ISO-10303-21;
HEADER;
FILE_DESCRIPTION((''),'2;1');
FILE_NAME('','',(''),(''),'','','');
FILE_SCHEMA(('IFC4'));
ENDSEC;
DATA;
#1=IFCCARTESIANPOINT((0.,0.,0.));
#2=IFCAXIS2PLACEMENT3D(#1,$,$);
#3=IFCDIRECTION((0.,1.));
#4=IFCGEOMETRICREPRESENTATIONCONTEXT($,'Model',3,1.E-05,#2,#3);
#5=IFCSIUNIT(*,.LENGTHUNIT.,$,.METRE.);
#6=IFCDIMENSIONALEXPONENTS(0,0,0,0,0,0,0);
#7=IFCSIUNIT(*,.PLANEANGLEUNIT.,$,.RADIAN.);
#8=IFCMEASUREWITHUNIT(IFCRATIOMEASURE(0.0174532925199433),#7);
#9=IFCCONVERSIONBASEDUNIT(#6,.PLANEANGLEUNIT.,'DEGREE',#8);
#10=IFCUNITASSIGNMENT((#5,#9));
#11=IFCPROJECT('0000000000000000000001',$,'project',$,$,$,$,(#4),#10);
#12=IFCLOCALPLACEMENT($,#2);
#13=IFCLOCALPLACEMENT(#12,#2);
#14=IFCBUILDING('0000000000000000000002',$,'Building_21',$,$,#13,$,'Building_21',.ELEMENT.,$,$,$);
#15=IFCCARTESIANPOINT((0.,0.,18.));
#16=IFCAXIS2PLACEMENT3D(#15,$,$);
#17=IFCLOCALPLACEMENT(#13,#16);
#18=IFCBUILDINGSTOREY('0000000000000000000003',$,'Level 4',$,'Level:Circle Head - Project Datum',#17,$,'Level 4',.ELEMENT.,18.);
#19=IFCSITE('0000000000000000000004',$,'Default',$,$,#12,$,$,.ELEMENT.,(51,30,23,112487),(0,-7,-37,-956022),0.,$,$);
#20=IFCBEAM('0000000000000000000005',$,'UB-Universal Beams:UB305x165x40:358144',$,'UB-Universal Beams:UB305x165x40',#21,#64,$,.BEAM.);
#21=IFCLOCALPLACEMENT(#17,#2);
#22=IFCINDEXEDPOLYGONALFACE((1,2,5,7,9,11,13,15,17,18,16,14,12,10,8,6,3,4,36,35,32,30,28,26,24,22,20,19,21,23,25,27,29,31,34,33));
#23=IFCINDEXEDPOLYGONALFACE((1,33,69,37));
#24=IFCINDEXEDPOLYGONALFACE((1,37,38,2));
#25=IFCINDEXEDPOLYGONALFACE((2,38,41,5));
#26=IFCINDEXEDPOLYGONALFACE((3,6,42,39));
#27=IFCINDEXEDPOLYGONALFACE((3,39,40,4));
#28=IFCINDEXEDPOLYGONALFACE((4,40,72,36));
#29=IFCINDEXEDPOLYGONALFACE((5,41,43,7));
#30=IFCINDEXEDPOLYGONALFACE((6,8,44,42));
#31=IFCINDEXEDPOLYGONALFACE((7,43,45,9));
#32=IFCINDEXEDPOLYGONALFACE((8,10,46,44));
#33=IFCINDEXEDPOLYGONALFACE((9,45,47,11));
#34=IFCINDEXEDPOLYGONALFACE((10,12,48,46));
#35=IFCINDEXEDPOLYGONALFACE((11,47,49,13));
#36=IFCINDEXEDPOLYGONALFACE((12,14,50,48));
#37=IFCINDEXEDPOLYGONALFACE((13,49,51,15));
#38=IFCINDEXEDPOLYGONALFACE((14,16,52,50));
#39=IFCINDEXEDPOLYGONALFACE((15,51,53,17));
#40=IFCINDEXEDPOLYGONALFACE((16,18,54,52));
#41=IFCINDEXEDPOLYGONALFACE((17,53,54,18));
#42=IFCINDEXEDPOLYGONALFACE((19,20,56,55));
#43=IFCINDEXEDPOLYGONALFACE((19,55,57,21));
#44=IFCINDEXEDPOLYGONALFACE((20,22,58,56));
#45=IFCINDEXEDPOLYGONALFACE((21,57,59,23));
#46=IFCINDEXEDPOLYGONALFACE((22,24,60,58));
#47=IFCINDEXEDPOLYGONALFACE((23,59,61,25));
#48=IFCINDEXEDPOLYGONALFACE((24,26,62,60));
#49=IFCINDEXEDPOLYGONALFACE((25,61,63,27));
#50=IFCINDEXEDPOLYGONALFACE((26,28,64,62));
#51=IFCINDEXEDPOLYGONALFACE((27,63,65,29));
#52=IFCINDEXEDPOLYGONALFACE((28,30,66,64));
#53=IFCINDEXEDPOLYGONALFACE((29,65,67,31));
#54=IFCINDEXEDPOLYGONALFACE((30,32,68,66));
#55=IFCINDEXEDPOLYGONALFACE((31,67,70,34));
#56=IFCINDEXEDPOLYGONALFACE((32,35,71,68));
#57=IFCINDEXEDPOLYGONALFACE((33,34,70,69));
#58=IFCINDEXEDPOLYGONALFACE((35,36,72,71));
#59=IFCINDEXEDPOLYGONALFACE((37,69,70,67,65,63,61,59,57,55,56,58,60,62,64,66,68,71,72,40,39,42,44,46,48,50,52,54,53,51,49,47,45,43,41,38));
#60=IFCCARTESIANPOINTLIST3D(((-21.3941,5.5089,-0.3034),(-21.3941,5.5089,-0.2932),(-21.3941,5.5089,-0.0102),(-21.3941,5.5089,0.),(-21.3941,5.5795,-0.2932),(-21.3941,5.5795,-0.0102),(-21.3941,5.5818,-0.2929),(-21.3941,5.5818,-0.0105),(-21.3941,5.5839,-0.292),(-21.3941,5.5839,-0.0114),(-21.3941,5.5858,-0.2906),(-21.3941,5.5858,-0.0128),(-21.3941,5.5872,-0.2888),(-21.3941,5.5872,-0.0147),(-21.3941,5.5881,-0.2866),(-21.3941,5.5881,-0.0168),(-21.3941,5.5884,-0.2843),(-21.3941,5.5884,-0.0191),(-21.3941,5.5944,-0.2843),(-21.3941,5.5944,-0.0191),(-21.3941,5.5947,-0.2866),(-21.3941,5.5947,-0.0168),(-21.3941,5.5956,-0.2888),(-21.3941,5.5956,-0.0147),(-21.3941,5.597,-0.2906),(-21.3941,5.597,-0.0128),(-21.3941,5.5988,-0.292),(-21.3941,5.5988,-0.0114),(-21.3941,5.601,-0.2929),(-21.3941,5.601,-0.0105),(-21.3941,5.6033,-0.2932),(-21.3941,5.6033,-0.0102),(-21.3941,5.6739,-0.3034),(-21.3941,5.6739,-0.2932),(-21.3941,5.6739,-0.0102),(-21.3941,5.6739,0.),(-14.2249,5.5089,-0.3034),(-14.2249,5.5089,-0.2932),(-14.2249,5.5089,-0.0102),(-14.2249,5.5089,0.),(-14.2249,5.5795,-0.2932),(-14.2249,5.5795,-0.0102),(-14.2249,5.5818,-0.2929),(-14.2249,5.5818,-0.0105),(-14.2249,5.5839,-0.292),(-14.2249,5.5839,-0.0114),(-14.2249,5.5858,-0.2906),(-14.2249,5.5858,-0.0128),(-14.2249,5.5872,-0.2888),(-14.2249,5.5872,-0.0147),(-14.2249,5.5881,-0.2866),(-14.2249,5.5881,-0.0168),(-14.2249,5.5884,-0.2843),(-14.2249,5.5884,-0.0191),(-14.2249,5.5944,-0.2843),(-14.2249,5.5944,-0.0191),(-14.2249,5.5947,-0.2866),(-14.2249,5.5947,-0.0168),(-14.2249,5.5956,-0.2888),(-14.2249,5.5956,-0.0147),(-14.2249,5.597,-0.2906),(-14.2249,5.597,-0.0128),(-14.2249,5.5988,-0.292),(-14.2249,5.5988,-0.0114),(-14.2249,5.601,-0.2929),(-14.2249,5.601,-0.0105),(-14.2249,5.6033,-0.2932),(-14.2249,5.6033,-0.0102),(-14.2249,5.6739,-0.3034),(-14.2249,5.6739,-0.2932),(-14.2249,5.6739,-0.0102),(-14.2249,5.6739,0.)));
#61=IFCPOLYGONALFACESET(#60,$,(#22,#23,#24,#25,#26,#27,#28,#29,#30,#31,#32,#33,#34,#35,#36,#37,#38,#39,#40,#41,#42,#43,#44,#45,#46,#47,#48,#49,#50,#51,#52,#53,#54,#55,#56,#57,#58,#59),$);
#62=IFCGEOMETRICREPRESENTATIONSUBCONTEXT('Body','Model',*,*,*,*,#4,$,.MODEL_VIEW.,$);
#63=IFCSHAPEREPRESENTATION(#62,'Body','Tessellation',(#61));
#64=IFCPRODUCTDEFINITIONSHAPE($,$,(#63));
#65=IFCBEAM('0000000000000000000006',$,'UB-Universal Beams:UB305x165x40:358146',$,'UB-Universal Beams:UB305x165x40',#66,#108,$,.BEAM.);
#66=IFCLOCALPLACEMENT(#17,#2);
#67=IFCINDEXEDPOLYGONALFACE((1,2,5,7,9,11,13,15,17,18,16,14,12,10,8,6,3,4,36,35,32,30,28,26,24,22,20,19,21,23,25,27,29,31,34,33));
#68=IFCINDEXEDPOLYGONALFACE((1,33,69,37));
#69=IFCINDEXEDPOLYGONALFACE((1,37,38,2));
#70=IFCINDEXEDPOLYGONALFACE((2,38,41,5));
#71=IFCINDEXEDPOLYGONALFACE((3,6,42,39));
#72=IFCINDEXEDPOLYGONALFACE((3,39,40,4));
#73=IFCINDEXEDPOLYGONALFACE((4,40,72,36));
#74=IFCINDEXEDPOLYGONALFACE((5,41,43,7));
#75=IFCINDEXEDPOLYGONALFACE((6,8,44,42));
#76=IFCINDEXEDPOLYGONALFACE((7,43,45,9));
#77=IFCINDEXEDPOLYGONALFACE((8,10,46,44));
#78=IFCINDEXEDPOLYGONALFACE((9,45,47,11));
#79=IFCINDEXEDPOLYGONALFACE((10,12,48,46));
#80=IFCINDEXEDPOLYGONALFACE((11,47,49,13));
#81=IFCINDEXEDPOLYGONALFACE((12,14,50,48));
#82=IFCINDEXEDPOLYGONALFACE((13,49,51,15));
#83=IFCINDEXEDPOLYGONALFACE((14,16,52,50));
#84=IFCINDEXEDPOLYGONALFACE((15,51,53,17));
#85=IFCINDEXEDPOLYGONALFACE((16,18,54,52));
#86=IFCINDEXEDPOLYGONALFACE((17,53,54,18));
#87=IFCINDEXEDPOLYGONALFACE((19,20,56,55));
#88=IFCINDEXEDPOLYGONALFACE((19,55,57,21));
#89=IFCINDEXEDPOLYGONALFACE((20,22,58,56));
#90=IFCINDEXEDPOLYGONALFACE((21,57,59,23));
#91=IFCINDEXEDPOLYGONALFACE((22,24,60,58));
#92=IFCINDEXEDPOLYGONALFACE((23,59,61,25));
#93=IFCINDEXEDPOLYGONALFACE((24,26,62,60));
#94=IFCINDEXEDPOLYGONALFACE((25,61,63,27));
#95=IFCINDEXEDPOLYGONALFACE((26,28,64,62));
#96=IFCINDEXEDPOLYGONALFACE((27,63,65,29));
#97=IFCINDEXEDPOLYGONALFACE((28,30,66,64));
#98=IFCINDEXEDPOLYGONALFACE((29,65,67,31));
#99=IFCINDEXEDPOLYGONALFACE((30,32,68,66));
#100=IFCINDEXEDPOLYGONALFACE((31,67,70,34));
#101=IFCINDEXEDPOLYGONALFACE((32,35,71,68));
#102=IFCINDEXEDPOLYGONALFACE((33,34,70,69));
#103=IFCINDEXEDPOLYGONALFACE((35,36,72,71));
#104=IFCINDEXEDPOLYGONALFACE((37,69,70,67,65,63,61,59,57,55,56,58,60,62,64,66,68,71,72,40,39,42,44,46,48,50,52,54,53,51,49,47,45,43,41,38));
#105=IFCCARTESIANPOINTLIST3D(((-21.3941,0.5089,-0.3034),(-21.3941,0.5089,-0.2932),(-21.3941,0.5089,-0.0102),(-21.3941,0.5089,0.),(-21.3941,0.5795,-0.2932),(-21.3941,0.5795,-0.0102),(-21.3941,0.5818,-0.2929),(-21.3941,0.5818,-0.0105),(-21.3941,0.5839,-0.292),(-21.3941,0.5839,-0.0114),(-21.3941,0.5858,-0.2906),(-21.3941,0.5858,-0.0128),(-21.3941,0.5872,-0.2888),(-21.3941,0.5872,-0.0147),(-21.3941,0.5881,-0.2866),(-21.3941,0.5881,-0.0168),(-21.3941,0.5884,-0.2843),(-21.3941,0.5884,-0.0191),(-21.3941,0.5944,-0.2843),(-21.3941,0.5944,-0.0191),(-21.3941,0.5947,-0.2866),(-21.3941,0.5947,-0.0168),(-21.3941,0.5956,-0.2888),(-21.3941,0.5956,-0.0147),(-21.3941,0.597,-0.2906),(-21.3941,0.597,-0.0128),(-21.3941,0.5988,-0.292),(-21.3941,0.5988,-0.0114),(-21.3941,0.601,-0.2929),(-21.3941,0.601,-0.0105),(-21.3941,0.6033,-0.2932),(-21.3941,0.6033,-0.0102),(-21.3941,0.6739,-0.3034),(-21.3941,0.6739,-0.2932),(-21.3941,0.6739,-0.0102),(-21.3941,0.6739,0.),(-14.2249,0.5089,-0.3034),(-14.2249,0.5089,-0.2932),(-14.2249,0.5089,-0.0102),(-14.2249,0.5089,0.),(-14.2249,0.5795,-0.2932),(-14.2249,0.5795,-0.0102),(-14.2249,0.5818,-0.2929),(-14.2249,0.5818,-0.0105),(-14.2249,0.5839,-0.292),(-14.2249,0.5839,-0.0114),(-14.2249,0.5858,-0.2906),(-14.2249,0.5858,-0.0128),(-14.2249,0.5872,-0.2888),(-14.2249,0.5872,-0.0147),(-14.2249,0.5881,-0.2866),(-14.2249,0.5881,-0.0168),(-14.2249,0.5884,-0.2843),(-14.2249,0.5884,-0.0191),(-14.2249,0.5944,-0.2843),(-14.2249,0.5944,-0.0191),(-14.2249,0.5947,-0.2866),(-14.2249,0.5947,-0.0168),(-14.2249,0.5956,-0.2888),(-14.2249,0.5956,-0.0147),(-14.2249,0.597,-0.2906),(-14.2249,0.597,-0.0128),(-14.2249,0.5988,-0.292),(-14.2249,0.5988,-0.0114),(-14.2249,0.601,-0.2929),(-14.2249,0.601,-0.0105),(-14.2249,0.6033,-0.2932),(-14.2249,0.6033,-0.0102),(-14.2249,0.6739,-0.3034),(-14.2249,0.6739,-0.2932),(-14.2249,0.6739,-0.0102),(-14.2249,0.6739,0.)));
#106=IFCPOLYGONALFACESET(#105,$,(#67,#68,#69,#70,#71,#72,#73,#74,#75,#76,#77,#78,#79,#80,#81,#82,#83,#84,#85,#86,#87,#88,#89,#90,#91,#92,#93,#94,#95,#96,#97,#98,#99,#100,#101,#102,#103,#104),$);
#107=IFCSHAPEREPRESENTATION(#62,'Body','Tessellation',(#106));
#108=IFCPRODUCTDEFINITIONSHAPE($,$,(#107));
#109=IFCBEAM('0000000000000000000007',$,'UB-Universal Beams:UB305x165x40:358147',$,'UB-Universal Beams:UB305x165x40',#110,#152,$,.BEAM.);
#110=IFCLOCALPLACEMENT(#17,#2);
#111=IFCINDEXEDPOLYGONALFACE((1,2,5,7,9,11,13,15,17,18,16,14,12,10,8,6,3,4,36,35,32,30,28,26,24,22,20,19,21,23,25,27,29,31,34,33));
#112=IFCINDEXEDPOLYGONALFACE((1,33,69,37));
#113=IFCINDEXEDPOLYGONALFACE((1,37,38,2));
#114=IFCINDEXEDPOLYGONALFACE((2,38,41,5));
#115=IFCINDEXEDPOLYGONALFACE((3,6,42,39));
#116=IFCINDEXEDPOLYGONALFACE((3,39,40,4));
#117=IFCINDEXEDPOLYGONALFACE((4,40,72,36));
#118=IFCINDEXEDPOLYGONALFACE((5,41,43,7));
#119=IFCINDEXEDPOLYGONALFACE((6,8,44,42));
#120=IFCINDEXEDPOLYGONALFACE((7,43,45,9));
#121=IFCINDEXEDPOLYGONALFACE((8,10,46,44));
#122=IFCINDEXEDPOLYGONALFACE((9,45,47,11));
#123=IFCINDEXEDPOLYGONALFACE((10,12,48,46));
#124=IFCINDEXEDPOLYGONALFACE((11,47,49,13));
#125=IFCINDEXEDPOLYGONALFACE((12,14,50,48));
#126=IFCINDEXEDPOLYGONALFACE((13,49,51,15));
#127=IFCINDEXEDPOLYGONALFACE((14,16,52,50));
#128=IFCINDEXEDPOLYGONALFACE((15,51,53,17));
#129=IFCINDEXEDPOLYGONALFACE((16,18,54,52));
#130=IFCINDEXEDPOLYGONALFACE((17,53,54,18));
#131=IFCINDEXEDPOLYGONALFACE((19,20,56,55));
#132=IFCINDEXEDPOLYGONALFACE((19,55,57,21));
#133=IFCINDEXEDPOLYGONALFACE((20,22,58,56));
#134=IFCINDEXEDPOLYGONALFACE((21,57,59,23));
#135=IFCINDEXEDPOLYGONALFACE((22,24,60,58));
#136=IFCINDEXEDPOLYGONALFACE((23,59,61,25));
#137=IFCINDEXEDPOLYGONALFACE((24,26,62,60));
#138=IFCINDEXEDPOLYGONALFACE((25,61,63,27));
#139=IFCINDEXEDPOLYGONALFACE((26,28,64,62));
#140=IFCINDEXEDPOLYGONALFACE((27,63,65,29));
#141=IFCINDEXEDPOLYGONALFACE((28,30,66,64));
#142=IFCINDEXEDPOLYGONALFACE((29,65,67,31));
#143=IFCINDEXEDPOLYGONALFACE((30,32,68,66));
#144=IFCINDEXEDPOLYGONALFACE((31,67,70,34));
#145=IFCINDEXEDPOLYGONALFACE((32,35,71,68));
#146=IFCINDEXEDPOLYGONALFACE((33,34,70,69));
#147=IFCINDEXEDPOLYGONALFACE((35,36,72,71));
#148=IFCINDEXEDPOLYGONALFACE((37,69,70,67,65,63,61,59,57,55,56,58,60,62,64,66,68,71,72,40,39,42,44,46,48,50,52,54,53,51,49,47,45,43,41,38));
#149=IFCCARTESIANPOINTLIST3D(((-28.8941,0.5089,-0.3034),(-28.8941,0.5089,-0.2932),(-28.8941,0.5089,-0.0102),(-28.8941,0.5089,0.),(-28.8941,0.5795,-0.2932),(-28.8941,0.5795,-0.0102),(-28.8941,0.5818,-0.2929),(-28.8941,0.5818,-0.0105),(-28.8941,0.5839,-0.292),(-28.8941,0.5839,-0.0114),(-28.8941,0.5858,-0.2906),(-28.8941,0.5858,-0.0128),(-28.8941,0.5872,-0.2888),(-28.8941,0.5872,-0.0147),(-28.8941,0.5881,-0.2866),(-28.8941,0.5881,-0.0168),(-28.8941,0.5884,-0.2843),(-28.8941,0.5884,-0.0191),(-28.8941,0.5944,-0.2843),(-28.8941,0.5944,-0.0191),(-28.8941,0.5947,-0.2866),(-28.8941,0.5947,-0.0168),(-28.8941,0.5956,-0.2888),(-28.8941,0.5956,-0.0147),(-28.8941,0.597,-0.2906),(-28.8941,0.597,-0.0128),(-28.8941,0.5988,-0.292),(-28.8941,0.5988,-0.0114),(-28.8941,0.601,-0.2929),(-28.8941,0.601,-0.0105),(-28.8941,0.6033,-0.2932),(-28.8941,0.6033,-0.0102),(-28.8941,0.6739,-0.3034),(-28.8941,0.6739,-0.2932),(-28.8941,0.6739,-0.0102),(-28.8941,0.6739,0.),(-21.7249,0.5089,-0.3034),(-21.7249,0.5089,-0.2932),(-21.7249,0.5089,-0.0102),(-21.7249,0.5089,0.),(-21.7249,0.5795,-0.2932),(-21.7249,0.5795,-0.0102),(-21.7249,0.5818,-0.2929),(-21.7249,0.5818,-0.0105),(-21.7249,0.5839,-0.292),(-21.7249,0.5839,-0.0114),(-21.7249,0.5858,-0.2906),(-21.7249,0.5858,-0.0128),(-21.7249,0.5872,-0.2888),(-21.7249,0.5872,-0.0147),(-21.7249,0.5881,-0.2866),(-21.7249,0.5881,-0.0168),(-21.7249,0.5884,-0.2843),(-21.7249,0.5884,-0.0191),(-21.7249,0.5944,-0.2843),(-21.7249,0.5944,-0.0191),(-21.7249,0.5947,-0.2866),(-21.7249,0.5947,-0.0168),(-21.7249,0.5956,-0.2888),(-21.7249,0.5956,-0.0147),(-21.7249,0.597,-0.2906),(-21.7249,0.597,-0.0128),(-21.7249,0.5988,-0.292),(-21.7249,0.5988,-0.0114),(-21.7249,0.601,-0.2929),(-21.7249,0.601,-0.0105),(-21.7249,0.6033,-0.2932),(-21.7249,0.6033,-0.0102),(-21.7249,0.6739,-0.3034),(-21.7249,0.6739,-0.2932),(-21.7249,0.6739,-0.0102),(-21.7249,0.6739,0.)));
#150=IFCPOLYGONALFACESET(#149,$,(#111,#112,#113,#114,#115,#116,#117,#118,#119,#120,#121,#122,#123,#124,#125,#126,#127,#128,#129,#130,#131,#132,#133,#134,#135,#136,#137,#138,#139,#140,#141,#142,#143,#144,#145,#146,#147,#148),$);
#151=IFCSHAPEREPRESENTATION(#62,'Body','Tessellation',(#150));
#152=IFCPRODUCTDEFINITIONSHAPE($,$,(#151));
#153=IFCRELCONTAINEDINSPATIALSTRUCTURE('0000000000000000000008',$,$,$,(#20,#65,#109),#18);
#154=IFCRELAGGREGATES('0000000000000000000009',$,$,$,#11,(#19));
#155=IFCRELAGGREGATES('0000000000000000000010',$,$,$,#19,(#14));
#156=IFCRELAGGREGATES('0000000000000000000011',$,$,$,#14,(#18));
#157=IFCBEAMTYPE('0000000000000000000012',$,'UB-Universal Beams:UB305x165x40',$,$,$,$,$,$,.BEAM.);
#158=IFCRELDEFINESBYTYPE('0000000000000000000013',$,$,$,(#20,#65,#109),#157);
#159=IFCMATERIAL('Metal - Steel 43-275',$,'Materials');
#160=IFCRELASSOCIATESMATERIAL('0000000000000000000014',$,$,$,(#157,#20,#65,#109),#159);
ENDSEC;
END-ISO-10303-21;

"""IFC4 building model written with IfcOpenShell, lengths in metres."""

from ifc_helpers import new_model, entity, si_unit, converted_unit, direction, frame, frame_2d, origin, place, context, subcontext, project, spatial, polyline, circle_curve, parameter, trimmed, segment, composite_curve, i_section, outline, extrude, source, transform, mapped, material, material_profile, profile_set, profile_usage, type_object, type_shapes, element, save


model = new_model("IFC4")

# Units and contexts
model_context = context("Model", 3, precision=1e-05, world=origin(), true_north=direction((0.0, 1.0)))
body_context = subcontext(model_context, "Body", "Model", "MODEL_VIEW")
ifc_project = project(units=[si_unit("LENGTHUNIT", "METRE"), converted_unit("PLANEANGLEUNIT", "DEGREE", entity("IfcRatioMeasure", 0.0174532925199433), si_unit("PLANEANGLEUNIT", "RADIAN"), dimensions=[0, 0, 0, 0, 0, 0, 0])], contexts=[model_context])

# Site, building, storey
site_placement = place(None, origin())
site = spatial("IfcSite", under=ifc_project, at=site_placement, Name="Default", CompositionType="ELEMENT", RefLatitude=(51, 30, 23, 112487), RefLongitude=(0, -7, -37, -956022), RefElevation=0.0)
building_placement = place(site_placement, origin())
building = spatial("IfcBuilding", under=site, at=building_placement, Name="Building_21", LongName="Building_21", CompositionType="ELEMENT")
storey_placement = place(building_placement, frame((0.0, 0.0, 18.0)))
storey = spatial("IfcBuildingStorey", under=building, at=storey_placement, Name="Level 4", ObjectType="Level:Circle Head - Project Datum", LongName="Level 4", CompositionType="ELEMENT", Elevation=18.0)

# Beams
ifc_material_1 = material(Name="Metal - Steel 43-275", Category="Materials")
ifc_material_profile_1 = material_profile(ifc_material_1, outline(composite_curve([segment(polyline([(0.0119, -0.1415, 0.0), (0.0825, -0.1415, 0.0)]), True, "CONTINUOUS"), segment(polyline([(0.0825, -0.1415, 0.0), (0.0825, -0.1517, 0.0)]), True, "CONTINUOUS"), segment(polyline([(0.0825, -0.1517, 0.0), (-0.0825, -0.1517, 0.0)]), True, "CONTINUOUS"), segment(polyline([(-0.0825, -0.1517, 0.0), (-0.0825, -0.1415, 0.0)]), True, "CONTINUOUS"), segment(polyline([(-0.0825, -0.1415, 0.0), (-0.0119, -0.1415, 0.0)]), True, "CONTINUOUS"), segment(trimmed(circle_curve(frame((-0.0119, -0.1326, 0.0), z_axis=(0.0, 0.0, 1.0), x_axis=(-1.0, 0.0, 0.0)), 0.0089), [parameter(90.0)], [parameter(180.0)], True, "PARAMETER"), True, "CONTINUOUS"), segment(polyline([(-0.003, -0.1326, 0.0), (-0.003, 0.1326, 0.0)]), True, "CONTINUOUS"), segment(trimmed(circle_curve(frame((-0.0119, 0.1326, 0.0), z_axis=(0.0, 0.0, 1.0), x_axis=(-1.0, 0.0, 0.0)), 0.0089), [parameter(180.0)], [parameter(270.0)], True, "PARAMETER"), True, "CONTINUOUS"), segment(polyline([(-0.0119, 0.1415, 0.0), (-0.0825, 0.1415, 0.0)]), True, "CONTINUOUS"), segment(polyline([(-0.0825, 0.1415, 0.0), (-0.0825, 0.1517, 0.0)]), True, "CONTINUOUS"), segment(polyline([(-0.0825, 0.1517, 0.0), (0.0825, 0.1517, 0.0)]), True, "CONTINUOUS"), segment(polyline([(0.0825, 0.1517, 0.0), (0.0825, 0.1415, 0.0)]), True, "CONTINUOUS"), segment(polyline([(0.0825, 0.1415, 0.0), (0.0119, 0.1415, 0.0)]), True, "CONTINUOUS"), segment(trimmed(circle_curve(frame((0.0119, 0.1326, 0.0), z_axis=(0.0, 0.0, 1.0), x_axis=(-1.0, 0.0, 0.0)), 0.0089), [parameter(270.0)], [parameter(0.0)], True, "PARAMETER"), True, "CONTINUOUS"), segment(polyline([(0.003, 0.1326, 0.0), (0.003, -0.1326, 0.0)]), True, "CONTINUOUS"), segment(trimmed(circle_curve(frame((0.0119, -0.1326, 0.0), z_axis=(0.0, 0.0, 1.0), x_axis=(-1.0, 0.0, 0.0)), 0.0089), [parameter(0.0)], [parameter(90.0)], True, "PARAMETER"), True, "CONTINUOUS")], self_intersect=False), kind="CURVE"), Name="UB305x165x40")
ifc_material_profile_2 = material_profile(ifc_material_1, outline(composite_curve([segment(polyline([(-1.3346, 0.0825, -0.1415), (-1.3346, 0.0825, -0.1517)]), True, "CONTINUOUS"), segment(polyline([(-1.3346, 0.0825, -0.1517), (-1.3346, -0.0825, -0.1517)]), True, "CONTINUOUS"), segment(polyline([(-1.3346, -0.0825, -0.1517), (-1.3346, -0.0825, -0.1415)]), True, "CONTINUOUS"), segment(polyline([(-1.3346, -0.0825, -0.1415), (-1.3346, -0.003, -0.1415)]), True, "CONTINUOUS"), segment(polyline([(-1.3346, -0.003, -0.1415), (-1.3346, -0.003, 0.1415)]), True, "CONTINUOUS"), segment(polyline([(-1.3346, -0.003, 0.1415), (-1.3346, -0.0825, 0.1415)]), True, "CONTINUOUS"), segment(polyline([(-1.3346, -0.0825, 0.1415), (-1.3346, -0.0825, 0.1517)]), True, "CONTINUOUS"), segment(polyline([(-1.3346, -0.0825, 0.1517), (-1.3346, 0.0825, 0.1517)]), True, "CONTINUOUS"), segment(polyline([(-1.3346, 0.0825, 0.1517), (-1.3346, 0.0825, 0.1415)]), True, "CONTINUOUS"), segment(polyline([(-1.3346, 0.0825, 0.1415), (-1.3346, 0.003, 0.1415)]), True, "CONTINUOUS"), segment(polyline([(-1.3346, 0.003, 0.1415), (-1.3346, 0.003, -0.1415)]), True, "CONTINUOUS"), segment(polyline([(-1.3346, 0.003, -0.1415), (-1.3346, 0.0825, -0.1415)]), True, "CONTINUOUS")], self_intersect=False), kind="CURVE"), Name="UB305x165x40")
ifc_profile_set = profile_set([ifc_material_profile_1, ifc_material_profile_2], Name="UB305x165x40")
beam_type_1 = type_object("IfcBeamType", Name="UB-Universal Beams:UB305x165x40", PredefinedType="BEAM", material=ifc_profile_set)
shared_shape_1 = source(origin(), body_context, "Body", "SweptSolid", [
    extrude(i_section(OverallWidth=0.165, OverallDepth=0.3034, WebThickness=0.006, FlangeThickness=0.0102, FilletRadius=0.0089, at=frame_2d((0.0, 0.0), x_axis=(0.0, 1.0))), frame((-3.5846, 0.0, 0.0), z_axis=(1.0, 0.0, 0.0), x_axis=(0.0, 0.0, -1.0)), (0.0, 0.0, 1.0), 7.1692),
])
type_shapes(beam_type_1, [shared_shape_1])
ifc_profile_usage_1 = profile_usage(ifc_profile_set, cardinal=8)
beam_1_placement = place(storey_placement, frame((-17.8095, 5.5914, -0.1517), z_axis=(0.0, 0.0, 1.0), x_axis=(-1.0, 0.0, 0.0)))
element("IfcBeam", 1, at=beam_1_placement, inside=storey, type_object=beam_type_1, material=ifc_profile_usage_1, Name="UB-Universal Beams:UB305x165x40:358144", ObjectType="UB-Universal Beams:UB305x165x40", PredefinedType="BEAM", context=body_context, shape_type="MappedRepresentation", body=[
    mapped(shared_shape_1, transform((0.0, 0.0, 0.0), scale=1.0)),
])
ifc_profile_usage_2 = profile_usage(ifc_profile_set, cardinal=8)
beam_2_placement = place(storey_placement, frame((-17.8095, 0.5914, -0.1517)))
element("IfcBeam", 2, at=beam_2_placement, inside=storey, type_object=beam_type_1, material=ifc_profile_usage_2, Name="UB-Universal Beams:UB305x165x40:358146", ObjectType="UB-Universal Beams:UB305x165x40", PredefinedType="BEAM", context=body_context, shape_type="MappedRepresentation", body=[
    mapped(shared_shape_1, transform((0.0, 0.0, 0.0), scale=1.0)),
])
ifc_profile_usage_3 = profile_usage(ifc_profile_set, cardinal=8)
beam_3_placement = place(storey_placement, frame((-25.3095, 0.5914, -0.1517)))
element("IfcBeam", 3, at=beam_3_placement, inside=storey, type_object=beam_type_1, material=ifc_profile_usage_3, Name="UB-Universal Beams:UB305x165x40:358147", ObjectType="UB-Universal Beams:UB305x165x40", PredefinedType="BEAM", context=body_context, shape_type="MappedRepresentation", body=[
    mapped(shared_shape_1, transform((0.0, 0.0, 0.0), scale=1.0)),
])

save(model, "model.ifc")
